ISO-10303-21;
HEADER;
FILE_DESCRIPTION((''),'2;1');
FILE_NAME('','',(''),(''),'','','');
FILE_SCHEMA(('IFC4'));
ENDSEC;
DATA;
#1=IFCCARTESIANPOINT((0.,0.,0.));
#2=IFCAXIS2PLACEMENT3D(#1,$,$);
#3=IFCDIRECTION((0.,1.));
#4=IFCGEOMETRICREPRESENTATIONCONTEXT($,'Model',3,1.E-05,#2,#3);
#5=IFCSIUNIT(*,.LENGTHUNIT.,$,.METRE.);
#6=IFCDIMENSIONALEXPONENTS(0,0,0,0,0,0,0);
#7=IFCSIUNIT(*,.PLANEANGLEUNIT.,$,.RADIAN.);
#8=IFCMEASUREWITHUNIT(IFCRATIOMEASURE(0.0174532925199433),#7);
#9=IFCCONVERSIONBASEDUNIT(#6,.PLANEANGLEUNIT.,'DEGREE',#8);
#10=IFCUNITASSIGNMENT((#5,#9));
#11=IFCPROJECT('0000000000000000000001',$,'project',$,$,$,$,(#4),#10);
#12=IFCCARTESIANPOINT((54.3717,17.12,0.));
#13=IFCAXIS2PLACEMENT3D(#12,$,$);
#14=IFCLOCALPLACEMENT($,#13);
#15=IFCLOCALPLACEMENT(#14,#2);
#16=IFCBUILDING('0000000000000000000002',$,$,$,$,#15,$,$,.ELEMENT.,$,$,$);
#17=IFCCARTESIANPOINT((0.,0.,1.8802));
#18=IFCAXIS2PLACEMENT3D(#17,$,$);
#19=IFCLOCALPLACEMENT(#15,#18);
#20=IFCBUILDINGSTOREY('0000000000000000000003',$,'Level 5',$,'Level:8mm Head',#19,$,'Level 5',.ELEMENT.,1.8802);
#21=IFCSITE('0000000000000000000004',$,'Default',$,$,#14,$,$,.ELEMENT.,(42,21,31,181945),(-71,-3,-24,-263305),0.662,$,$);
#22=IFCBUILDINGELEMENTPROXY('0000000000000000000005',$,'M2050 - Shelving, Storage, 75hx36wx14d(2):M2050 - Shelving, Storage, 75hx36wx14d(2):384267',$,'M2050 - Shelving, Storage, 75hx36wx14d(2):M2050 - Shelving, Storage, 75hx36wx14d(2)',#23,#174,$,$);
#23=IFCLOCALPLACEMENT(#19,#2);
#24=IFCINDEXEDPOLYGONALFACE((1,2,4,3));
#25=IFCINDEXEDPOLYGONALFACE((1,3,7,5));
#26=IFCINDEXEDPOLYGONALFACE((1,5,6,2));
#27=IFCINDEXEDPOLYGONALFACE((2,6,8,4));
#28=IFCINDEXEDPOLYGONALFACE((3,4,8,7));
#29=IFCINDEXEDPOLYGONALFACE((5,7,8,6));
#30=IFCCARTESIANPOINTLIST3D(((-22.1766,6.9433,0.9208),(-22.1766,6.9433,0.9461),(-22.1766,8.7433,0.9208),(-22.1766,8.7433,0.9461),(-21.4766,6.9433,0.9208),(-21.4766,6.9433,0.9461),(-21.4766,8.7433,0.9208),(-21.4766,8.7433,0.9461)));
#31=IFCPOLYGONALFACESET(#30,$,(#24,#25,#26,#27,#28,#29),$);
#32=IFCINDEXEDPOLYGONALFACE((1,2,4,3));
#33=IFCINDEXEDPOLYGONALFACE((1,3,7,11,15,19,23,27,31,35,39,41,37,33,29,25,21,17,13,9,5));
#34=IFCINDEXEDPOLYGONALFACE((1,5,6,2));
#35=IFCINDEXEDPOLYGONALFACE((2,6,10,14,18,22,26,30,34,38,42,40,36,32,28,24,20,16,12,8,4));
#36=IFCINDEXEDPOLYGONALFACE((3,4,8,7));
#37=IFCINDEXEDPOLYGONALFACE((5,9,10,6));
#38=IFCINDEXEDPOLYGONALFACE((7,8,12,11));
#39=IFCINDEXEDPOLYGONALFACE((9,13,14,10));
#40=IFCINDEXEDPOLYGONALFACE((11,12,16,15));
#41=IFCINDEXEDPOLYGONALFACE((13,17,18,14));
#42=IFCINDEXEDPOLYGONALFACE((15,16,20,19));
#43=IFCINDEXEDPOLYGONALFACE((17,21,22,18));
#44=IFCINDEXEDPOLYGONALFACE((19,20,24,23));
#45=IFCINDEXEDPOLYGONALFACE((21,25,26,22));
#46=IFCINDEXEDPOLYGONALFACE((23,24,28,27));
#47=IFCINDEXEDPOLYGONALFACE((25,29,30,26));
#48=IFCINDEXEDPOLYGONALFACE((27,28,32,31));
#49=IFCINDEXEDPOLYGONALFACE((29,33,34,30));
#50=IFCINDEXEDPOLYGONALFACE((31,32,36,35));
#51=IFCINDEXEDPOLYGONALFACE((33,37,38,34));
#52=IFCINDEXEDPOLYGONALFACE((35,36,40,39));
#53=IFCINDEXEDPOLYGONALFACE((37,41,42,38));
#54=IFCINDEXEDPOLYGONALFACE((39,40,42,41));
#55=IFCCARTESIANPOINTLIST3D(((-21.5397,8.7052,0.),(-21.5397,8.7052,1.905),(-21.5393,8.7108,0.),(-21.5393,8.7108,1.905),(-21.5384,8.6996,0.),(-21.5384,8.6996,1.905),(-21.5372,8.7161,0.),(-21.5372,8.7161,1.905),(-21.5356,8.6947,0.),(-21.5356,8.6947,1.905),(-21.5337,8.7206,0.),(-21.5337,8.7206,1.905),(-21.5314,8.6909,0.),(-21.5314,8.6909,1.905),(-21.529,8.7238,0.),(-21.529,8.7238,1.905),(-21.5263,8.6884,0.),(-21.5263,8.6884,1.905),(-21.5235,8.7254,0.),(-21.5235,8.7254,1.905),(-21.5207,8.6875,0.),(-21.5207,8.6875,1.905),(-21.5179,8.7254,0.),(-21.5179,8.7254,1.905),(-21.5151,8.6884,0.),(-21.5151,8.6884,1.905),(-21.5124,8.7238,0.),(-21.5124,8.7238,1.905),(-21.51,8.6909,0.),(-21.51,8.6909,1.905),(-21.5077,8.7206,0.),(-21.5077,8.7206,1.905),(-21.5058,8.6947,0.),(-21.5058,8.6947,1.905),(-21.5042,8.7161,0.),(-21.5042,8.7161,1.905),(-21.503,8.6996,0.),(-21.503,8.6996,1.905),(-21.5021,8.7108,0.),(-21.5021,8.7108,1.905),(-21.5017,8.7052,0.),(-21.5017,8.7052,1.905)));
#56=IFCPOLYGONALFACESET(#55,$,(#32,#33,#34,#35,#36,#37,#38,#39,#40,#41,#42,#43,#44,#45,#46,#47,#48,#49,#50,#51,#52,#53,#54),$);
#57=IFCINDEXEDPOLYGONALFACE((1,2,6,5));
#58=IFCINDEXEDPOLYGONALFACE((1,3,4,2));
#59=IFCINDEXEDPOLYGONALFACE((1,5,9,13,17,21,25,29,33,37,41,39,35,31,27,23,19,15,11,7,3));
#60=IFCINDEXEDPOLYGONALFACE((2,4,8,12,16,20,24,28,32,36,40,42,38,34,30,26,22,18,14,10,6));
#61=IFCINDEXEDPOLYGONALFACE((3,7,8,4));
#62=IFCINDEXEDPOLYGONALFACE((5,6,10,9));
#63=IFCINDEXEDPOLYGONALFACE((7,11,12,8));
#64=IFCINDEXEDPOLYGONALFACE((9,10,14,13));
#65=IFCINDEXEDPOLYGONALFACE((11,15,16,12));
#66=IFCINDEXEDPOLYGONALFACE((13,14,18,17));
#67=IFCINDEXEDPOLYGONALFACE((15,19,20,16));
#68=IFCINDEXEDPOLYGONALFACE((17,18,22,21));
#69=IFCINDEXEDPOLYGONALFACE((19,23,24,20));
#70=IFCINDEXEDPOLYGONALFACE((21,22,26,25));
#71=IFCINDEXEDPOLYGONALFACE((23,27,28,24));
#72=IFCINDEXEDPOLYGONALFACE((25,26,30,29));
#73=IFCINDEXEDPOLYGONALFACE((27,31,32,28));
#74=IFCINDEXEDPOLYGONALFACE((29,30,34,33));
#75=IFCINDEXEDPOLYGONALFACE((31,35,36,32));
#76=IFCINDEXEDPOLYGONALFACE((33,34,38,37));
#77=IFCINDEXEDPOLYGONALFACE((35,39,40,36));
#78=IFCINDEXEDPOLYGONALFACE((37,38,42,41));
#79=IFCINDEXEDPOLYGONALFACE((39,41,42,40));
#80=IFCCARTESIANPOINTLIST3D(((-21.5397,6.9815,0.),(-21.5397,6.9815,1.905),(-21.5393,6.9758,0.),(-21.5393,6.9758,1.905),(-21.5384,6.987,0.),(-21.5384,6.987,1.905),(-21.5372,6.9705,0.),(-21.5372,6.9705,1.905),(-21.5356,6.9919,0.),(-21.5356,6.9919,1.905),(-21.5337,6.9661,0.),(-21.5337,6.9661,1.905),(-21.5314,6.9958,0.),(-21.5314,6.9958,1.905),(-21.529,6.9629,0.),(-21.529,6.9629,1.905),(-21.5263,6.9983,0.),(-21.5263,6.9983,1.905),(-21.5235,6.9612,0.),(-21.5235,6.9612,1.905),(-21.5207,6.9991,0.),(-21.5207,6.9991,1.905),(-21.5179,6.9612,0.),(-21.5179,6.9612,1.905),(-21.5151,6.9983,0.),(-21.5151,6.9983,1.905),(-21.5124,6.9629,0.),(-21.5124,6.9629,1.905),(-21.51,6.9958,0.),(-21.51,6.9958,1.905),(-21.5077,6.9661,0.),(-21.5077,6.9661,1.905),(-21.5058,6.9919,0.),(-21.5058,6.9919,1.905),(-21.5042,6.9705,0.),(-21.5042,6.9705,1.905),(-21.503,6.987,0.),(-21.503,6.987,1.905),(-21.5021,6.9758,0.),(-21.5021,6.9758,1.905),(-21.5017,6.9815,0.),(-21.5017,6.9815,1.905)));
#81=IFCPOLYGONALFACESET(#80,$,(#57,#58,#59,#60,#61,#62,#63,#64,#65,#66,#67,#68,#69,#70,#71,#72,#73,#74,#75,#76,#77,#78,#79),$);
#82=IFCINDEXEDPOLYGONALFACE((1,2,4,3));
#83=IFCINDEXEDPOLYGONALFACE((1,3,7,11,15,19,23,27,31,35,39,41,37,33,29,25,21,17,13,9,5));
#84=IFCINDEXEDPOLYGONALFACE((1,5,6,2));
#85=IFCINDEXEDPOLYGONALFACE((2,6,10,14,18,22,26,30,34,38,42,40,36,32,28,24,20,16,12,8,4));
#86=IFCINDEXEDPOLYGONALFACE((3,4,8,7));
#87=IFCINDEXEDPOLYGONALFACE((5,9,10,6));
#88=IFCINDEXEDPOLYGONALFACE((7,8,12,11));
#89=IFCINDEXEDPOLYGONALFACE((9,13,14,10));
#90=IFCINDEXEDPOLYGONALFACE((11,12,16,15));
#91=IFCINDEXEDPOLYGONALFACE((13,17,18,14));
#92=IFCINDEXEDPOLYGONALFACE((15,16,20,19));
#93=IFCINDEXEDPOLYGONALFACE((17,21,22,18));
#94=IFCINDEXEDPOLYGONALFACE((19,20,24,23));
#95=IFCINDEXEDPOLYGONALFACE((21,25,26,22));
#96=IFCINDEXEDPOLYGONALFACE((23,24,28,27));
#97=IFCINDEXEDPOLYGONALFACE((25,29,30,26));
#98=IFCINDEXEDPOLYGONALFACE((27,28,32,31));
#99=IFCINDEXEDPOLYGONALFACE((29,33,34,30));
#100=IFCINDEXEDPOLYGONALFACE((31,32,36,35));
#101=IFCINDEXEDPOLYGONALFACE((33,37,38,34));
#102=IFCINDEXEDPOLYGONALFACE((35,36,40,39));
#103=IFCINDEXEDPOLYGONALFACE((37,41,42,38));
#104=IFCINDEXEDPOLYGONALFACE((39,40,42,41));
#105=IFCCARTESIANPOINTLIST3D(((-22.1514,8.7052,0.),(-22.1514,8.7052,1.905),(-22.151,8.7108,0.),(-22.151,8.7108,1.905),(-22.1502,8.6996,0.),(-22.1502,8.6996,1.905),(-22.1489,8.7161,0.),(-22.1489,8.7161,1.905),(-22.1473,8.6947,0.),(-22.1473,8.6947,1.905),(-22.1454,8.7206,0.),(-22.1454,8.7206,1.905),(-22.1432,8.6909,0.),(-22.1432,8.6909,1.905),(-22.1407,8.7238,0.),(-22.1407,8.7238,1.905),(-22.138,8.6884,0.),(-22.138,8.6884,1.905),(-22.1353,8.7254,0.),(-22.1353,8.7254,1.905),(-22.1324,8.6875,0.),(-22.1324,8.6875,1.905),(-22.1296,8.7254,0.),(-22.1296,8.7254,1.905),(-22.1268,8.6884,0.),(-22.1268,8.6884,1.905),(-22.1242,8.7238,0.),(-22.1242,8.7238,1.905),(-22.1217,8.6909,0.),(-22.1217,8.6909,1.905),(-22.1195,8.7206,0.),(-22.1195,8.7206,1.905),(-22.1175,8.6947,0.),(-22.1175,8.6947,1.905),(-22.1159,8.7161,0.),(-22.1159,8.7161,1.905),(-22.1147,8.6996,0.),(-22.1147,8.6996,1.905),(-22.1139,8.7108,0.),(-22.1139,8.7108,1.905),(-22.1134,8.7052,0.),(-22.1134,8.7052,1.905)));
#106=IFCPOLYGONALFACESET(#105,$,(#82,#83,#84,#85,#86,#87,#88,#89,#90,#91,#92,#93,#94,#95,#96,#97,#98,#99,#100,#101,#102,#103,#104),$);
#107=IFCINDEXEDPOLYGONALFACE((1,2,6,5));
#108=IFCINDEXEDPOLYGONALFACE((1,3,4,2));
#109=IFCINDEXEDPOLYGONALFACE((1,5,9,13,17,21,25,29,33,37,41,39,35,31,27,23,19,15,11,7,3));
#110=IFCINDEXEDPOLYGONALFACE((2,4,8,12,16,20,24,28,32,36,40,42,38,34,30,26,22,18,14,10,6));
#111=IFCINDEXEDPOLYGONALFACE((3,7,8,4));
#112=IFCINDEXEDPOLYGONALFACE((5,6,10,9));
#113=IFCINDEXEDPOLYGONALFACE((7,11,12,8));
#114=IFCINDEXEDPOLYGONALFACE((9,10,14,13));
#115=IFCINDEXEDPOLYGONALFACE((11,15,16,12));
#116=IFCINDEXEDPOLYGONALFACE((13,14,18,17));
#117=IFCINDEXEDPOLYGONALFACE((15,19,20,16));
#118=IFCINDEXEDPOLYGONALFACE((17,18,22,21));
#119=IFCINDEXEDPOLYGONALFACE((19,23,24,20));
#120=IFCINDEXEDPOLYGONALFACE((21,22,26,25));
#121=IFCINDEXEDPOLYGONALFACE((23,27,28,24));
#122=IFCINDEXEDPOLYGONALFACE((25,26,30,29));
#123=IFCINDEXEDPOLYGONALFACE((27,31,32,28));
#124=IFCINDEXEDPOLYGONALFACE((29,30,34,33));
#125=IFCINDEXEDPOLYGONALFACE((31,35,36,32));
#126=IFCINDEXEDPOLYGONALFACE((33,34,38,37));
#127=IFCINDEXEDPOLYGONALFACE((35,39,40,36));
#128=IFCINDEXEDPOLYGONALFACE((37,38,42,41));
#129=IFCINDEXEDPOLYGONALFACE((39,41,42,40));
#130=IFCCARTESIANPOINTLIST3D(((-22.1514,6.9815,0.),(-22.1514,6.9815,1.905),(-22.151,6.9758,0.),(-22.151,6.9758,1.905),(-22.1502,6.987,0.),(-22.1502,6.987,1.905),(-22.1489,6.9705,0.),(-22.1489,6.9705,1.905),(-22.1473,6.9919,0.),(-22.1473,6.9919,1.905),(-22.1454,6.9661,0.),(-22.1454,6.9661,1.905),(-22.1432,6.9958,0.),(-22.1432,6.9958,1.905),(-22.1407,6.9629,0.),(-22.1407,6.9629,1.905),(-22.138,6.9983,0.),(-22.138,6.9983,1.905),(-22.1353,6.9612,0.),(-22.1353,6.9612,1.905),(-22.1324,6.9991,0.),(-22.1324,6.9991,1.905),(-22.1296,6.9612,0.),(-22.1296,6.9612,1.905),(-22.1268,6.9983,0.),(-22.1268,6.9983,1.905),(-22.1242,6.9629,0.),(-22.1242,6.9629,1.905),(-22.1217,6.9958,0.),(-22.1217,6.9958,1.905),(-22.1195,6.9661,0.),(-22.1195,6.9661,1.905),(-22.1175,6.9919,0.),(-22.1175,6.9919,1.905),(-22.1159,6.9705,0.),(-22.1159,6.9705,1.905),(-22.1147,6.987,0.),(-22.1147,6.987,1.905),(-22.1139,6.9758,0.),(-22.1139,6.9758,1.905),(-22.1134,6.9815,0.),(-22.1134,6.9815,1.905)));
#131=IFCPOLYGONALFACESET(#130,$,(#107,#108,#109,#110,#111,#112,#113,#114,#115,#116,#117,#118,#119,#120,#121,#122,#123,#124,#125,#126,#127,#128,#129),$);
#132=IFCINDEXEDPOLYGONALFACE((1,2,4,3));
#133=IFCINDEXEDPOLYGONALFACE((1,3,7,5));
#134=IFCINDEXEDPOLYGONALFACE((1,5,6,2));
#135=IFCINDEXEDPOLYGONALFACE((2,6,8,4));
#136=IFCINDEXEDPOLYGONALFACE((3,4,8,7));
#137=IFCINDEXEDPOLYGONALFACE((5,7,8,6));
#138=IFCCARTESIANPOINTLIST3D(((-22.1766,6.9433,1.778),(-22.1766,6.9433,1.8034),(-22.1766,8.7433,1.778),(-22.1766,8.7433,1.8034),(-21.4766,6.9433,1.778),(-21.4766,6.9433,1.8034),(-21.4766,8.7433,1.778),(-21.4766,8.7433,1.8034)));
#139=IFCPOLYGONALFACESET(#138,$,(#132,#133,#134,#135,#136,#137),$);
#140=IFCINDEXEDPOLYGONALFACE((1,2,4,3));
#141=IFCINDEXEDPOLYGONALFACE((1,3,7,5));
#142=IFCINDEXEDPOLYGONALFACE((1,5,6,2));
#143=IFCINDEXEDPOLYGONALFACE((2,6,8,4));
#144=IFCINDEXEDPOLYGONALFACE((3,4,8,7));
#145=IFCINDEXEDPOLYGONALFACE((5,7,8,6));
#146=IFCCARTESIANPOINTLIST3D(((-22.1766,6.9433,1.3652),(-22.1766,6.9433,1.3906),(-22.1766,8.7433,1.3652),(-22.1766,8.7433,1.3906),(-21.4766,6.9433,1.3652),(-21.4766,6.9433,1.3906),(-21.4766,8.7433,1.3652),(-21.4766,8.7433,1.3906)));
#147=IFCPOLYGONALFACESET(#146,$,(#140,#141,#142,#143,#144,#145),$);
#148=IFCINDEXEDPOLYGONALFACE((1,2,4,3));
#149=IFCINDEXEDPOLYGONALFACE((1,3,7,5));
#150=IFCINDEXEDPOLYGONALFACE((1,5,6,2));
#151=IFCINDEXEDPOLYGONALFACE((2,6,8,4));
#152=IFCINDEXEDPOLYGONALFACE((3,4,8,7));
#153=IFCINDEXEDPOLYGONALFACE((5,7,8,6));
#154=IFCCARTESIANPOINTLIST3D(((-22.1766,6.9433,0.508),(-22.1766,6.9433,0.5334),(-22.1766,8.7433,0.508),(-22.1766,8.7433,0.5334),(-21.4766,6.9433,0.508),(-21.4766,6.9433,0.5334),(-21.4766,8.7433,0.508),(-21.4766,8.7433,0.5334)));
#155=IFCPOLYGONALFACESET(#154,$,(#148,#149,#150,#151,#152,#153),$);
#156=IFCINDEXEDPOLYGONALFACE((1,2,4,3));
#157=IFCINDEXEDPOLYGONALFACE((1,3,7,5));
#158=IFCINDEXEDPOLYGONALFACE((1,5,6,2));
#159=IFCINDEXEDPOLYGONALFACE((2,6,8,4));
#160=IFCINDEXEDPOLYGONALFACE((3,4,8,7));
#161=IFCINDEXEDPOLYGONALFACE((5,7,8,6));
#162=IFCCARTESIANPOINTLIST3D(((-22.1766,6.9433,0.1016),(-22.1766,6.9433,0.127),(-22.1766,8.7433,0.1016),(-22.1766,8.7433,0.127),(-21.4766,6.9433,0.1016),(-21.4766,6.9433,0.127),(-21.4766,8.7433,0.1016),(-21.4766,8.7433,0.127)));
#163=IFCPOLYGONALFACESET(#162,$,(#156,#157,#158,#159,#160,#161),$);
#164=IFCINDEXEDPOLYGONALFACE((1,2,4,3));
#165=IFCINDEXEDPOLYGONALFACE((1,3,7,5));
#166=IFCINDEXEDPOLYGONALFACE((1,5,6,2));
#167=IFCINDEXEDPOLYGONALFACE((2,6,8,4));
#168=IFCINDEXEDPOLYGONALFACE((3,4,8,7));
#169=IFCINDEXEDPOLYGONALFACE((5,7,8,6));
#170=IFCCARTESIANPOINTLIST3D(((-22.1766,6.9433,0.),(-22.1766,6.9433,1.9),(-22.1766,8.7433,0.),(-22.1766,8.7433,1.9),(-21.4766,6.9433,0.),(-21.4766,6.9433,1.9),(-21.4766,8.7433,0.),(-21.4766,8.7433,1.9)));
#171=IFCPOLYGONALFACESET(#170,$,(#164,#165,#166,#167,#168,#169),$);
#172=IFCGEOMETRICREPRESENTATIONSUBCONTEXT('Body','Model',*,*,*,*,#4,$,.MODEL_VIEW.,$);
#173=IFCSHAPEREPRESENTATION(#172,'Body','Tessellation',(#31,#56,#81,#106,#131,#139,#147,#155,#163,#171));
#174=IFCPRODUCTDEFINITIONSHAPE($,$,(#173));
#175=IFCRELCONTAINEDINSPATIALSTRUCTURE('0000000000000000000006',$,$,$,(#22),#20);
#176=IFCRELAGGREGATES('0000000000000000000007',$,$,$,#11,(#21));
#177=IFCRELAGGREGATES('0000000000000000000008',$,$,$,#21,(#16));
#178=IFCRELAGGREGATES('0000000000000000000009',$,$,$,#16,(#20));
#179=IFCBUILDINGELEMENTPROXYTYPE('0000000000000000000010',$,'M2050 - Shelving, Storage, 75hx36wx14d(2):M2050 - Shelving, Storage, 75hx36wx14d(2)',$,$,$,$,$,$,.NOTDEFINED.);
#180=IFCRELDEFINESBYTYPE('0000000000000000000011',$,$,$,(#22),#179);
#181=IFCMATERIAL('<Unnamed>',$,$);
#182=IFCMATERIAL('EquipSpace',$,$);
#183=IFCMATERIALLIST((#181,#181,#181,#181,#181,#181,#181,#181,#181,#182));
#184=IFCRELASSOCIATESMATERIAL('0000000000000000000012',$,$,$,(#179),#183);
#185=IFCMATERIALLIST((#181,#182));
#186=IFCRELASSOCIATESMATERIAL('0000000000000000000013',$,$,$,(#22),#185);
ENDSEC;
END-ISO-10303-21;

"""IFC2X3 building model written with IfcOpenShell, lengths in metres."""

from ifc_helpers import new_model, entity, si_unit, converted_unit, direction, frame, frame_2d, origin, origin_2d_with_axis, place, context, subcontext, project, spatial, rectangle, circle, extrude, source, transform, mapped, material, material_list, type_object, type_shapes, element, save


model = new_model("IFC2X3")

# Units and contexts
model_context = context("Model", 3, precision=1e-05, world=origin(), true_north=direction((0.0, 1.0)))
body_context = subcontext(model_context, "Body", "Model", "MODEL_VIEW")
ifc_project = project(units=[si_unit("LENGTHUNIT", "METRE"), converted_unit("PLANEANGLEUNIT", "DEGREE", entity("IfcRatioMeasure", 0.0174532925199433), si_unit("PLANEANGLEUNIT", "RADIAN"), dimensions=[0, 0, 0, 0, 0, 0, 0])], contexts=[model_context])

# Site, building, storey
site_placement = place(None, frame((54.3717, 17.12, 0.0)))
site = spatial("IfcSite", under=ifc_project, at=site_placement, Name="Default", CompositionType="ELEMENT", RefLatitude=(42, 21, 31, 181945), RefLongitude=(-71, -3, -24, -263305), RefElevation=0.662)
building_placement = place(site_placement, origin())
building = spatial("IfcBuilding", under=site, at=building_placement, CompositionType="ELEMENT")
storey_placement = place(building_placement, frame((0.0, 0.0, 1.8802)))
storey = spatial("IfcBuildingStorey", under=building, at=storey_placement, Name="Level 5", ObjectType="Level:8mm Head", LongName="Level 5", CompositionType="ELEMENT", Elevation=1.8802)

# Building element proxy
ifc_material_1 = material(Name="<Unnamed>")
ifc_material_2 = material(Name="EquipSpace")
ifc_material_list_1 = material_list([ifc_material_1, ifc_material_1, ifc_material_1, ifc_material_1, ifc_material_1, ifc_material_1, ifc_material_1, ifc_material_1, ifc_material_1, ifc_material_2])
building_element_proxy_type = type_object("IfcBuildingElementProxyType", Name="M2050 - Shelving, Storage, 75hx36wx14d(2):M2050 - Shelving, Storage, 75hx36wx14d(2)", PredefinedType="NOTDEFINED", material=ifc_material_list_1)
shared_shape = source(origin(), body_context, "Body", "SweptSolid", [
    extrude(rectangle(XDim=1.8, YDim=0.7, at=origin_2d_with_axis()), frame((0.0, 0.0, 0.9207), z_axis=(0.0, 0.0, 1.0), x_axis=(-1.0, 0.0, 0.0)), (0.0, 0.0, 1.0), 0.0254),
    extrude(circle(Radius=0.0191, at=origin_2d_with_axis()), frame((0.8633, -0.3059, 0.0), z_axis=(0.0, 0.0, 1.0), x_axis=(-1.0, 0.0, 0.0)), (0.0, 0.0, 1.0), 1.905),
    extrude(circle(Radius=0.0191, at=origin_2d_with_axis()), frame((-0.8633, -0.3059, 0.0)), (0.0, 0.0, 1.0), 1.905),
    extrude(circle(Radius=0.0191, at=origin_2d_with_axis()), frame((0.8633, 0.3059, 0.0), z_axis=(0.0, 0.0, 1.0), x_axis=(-1.0, 0.0, 0.0)), (0.0, 0.0, 1.0), 1.905),
    extrude(circle(Radius=0.0191, at=origin_2d_with_axis()), frame((-0.8633, 0.3059, 0.0)), (0.0, 0.0, 1.0), 1.905),
    extrude(rectangle(XDim=1.8, YDim=0.7, at=origin_2d_with_axis()), frame((0.0, 0.0, 1.778), z_axis=(0.0, 0.0, 1.0), x_axis=(-1.0, 0.0, 0.0)), (0.0, 0.0, 1.0), 0.0254),
    extrude(rectangle(XDim=1.8, YDim=0.7, at=origin_2d_with_axis()), frame((0.0, 0.0, 1.3653), z_axis=(0.0, 0.0, 1.0), x_axis=(-1.0, 0.0, 0.0)), (0.0, 0.0, 1.0), 0.0254),
    extrude(rectangle(XDim=1.8, YDim=0.7, at=origin_2d_with_axis()), frame((0.0, 0.0, 0.508), z_axis=(0.0, 0.0, 1.0), x_axis=(-1.0, 0.0, 0.0)), (0.0, 0.0, 1.0), 0.0254),
    extrude(rectangle(XDim=1.8, YDim=0.7, at=origin_2d_with_axis()), frame((0.0, 0.0, 0.1016), z_axis=(0.0, 0.0, 1.0), x_axis=(-1.0, 0.0, 0.0)), (0.0, 0.0, 1.0), 0.0254),
    extrude(rectangle(XDim=0.7, YDim=1.8, at=frame_2d((0.0, 0.18), x_axis=(1.0, 0.0))), frame((-0.18, 0.0, 0.0), z_axis=(0.0, 0.0, 1.0), x_axis=(0.0, -1.0, 0.0)), (0.0, 0.0, 1.0), 1.9),
])
type_shapes(building_element_proxy_type, [shared_shape])
ifc_material_list_2 = material_list([ifc_material_1, ifc_material_2])
proxy_1_placement = place(storey_placement, frame((-21.8266, 7.8433, 0.0), z_axis=(0.0, 0.0, 1.0), x_axis=(0.0, 1.0, 0.0)))
element("IfcBuildingElementProxy", 1, at=proxy_1_placement, inside=storey, type_object=building_element_proxy_type, material=ifc_material_list_2, Name="M2050 - Shelving, Storage, 75hx36wx14d(2):M2050 - Shelving, Storage, 75hx36wx14d(2):384267", ObjectType="M2050 - Shelving, Storage, 75hx36wx14d(2):M2050 - Shelving, Storage, 75hx36wx14d(2)", context=body_context, shape_type="MappedRepresentation", body=[
    mapped(shared_shape, transform((0.0, 0.0, 0.0), scale=1.0)),
])

save(model, "model.ifc")
